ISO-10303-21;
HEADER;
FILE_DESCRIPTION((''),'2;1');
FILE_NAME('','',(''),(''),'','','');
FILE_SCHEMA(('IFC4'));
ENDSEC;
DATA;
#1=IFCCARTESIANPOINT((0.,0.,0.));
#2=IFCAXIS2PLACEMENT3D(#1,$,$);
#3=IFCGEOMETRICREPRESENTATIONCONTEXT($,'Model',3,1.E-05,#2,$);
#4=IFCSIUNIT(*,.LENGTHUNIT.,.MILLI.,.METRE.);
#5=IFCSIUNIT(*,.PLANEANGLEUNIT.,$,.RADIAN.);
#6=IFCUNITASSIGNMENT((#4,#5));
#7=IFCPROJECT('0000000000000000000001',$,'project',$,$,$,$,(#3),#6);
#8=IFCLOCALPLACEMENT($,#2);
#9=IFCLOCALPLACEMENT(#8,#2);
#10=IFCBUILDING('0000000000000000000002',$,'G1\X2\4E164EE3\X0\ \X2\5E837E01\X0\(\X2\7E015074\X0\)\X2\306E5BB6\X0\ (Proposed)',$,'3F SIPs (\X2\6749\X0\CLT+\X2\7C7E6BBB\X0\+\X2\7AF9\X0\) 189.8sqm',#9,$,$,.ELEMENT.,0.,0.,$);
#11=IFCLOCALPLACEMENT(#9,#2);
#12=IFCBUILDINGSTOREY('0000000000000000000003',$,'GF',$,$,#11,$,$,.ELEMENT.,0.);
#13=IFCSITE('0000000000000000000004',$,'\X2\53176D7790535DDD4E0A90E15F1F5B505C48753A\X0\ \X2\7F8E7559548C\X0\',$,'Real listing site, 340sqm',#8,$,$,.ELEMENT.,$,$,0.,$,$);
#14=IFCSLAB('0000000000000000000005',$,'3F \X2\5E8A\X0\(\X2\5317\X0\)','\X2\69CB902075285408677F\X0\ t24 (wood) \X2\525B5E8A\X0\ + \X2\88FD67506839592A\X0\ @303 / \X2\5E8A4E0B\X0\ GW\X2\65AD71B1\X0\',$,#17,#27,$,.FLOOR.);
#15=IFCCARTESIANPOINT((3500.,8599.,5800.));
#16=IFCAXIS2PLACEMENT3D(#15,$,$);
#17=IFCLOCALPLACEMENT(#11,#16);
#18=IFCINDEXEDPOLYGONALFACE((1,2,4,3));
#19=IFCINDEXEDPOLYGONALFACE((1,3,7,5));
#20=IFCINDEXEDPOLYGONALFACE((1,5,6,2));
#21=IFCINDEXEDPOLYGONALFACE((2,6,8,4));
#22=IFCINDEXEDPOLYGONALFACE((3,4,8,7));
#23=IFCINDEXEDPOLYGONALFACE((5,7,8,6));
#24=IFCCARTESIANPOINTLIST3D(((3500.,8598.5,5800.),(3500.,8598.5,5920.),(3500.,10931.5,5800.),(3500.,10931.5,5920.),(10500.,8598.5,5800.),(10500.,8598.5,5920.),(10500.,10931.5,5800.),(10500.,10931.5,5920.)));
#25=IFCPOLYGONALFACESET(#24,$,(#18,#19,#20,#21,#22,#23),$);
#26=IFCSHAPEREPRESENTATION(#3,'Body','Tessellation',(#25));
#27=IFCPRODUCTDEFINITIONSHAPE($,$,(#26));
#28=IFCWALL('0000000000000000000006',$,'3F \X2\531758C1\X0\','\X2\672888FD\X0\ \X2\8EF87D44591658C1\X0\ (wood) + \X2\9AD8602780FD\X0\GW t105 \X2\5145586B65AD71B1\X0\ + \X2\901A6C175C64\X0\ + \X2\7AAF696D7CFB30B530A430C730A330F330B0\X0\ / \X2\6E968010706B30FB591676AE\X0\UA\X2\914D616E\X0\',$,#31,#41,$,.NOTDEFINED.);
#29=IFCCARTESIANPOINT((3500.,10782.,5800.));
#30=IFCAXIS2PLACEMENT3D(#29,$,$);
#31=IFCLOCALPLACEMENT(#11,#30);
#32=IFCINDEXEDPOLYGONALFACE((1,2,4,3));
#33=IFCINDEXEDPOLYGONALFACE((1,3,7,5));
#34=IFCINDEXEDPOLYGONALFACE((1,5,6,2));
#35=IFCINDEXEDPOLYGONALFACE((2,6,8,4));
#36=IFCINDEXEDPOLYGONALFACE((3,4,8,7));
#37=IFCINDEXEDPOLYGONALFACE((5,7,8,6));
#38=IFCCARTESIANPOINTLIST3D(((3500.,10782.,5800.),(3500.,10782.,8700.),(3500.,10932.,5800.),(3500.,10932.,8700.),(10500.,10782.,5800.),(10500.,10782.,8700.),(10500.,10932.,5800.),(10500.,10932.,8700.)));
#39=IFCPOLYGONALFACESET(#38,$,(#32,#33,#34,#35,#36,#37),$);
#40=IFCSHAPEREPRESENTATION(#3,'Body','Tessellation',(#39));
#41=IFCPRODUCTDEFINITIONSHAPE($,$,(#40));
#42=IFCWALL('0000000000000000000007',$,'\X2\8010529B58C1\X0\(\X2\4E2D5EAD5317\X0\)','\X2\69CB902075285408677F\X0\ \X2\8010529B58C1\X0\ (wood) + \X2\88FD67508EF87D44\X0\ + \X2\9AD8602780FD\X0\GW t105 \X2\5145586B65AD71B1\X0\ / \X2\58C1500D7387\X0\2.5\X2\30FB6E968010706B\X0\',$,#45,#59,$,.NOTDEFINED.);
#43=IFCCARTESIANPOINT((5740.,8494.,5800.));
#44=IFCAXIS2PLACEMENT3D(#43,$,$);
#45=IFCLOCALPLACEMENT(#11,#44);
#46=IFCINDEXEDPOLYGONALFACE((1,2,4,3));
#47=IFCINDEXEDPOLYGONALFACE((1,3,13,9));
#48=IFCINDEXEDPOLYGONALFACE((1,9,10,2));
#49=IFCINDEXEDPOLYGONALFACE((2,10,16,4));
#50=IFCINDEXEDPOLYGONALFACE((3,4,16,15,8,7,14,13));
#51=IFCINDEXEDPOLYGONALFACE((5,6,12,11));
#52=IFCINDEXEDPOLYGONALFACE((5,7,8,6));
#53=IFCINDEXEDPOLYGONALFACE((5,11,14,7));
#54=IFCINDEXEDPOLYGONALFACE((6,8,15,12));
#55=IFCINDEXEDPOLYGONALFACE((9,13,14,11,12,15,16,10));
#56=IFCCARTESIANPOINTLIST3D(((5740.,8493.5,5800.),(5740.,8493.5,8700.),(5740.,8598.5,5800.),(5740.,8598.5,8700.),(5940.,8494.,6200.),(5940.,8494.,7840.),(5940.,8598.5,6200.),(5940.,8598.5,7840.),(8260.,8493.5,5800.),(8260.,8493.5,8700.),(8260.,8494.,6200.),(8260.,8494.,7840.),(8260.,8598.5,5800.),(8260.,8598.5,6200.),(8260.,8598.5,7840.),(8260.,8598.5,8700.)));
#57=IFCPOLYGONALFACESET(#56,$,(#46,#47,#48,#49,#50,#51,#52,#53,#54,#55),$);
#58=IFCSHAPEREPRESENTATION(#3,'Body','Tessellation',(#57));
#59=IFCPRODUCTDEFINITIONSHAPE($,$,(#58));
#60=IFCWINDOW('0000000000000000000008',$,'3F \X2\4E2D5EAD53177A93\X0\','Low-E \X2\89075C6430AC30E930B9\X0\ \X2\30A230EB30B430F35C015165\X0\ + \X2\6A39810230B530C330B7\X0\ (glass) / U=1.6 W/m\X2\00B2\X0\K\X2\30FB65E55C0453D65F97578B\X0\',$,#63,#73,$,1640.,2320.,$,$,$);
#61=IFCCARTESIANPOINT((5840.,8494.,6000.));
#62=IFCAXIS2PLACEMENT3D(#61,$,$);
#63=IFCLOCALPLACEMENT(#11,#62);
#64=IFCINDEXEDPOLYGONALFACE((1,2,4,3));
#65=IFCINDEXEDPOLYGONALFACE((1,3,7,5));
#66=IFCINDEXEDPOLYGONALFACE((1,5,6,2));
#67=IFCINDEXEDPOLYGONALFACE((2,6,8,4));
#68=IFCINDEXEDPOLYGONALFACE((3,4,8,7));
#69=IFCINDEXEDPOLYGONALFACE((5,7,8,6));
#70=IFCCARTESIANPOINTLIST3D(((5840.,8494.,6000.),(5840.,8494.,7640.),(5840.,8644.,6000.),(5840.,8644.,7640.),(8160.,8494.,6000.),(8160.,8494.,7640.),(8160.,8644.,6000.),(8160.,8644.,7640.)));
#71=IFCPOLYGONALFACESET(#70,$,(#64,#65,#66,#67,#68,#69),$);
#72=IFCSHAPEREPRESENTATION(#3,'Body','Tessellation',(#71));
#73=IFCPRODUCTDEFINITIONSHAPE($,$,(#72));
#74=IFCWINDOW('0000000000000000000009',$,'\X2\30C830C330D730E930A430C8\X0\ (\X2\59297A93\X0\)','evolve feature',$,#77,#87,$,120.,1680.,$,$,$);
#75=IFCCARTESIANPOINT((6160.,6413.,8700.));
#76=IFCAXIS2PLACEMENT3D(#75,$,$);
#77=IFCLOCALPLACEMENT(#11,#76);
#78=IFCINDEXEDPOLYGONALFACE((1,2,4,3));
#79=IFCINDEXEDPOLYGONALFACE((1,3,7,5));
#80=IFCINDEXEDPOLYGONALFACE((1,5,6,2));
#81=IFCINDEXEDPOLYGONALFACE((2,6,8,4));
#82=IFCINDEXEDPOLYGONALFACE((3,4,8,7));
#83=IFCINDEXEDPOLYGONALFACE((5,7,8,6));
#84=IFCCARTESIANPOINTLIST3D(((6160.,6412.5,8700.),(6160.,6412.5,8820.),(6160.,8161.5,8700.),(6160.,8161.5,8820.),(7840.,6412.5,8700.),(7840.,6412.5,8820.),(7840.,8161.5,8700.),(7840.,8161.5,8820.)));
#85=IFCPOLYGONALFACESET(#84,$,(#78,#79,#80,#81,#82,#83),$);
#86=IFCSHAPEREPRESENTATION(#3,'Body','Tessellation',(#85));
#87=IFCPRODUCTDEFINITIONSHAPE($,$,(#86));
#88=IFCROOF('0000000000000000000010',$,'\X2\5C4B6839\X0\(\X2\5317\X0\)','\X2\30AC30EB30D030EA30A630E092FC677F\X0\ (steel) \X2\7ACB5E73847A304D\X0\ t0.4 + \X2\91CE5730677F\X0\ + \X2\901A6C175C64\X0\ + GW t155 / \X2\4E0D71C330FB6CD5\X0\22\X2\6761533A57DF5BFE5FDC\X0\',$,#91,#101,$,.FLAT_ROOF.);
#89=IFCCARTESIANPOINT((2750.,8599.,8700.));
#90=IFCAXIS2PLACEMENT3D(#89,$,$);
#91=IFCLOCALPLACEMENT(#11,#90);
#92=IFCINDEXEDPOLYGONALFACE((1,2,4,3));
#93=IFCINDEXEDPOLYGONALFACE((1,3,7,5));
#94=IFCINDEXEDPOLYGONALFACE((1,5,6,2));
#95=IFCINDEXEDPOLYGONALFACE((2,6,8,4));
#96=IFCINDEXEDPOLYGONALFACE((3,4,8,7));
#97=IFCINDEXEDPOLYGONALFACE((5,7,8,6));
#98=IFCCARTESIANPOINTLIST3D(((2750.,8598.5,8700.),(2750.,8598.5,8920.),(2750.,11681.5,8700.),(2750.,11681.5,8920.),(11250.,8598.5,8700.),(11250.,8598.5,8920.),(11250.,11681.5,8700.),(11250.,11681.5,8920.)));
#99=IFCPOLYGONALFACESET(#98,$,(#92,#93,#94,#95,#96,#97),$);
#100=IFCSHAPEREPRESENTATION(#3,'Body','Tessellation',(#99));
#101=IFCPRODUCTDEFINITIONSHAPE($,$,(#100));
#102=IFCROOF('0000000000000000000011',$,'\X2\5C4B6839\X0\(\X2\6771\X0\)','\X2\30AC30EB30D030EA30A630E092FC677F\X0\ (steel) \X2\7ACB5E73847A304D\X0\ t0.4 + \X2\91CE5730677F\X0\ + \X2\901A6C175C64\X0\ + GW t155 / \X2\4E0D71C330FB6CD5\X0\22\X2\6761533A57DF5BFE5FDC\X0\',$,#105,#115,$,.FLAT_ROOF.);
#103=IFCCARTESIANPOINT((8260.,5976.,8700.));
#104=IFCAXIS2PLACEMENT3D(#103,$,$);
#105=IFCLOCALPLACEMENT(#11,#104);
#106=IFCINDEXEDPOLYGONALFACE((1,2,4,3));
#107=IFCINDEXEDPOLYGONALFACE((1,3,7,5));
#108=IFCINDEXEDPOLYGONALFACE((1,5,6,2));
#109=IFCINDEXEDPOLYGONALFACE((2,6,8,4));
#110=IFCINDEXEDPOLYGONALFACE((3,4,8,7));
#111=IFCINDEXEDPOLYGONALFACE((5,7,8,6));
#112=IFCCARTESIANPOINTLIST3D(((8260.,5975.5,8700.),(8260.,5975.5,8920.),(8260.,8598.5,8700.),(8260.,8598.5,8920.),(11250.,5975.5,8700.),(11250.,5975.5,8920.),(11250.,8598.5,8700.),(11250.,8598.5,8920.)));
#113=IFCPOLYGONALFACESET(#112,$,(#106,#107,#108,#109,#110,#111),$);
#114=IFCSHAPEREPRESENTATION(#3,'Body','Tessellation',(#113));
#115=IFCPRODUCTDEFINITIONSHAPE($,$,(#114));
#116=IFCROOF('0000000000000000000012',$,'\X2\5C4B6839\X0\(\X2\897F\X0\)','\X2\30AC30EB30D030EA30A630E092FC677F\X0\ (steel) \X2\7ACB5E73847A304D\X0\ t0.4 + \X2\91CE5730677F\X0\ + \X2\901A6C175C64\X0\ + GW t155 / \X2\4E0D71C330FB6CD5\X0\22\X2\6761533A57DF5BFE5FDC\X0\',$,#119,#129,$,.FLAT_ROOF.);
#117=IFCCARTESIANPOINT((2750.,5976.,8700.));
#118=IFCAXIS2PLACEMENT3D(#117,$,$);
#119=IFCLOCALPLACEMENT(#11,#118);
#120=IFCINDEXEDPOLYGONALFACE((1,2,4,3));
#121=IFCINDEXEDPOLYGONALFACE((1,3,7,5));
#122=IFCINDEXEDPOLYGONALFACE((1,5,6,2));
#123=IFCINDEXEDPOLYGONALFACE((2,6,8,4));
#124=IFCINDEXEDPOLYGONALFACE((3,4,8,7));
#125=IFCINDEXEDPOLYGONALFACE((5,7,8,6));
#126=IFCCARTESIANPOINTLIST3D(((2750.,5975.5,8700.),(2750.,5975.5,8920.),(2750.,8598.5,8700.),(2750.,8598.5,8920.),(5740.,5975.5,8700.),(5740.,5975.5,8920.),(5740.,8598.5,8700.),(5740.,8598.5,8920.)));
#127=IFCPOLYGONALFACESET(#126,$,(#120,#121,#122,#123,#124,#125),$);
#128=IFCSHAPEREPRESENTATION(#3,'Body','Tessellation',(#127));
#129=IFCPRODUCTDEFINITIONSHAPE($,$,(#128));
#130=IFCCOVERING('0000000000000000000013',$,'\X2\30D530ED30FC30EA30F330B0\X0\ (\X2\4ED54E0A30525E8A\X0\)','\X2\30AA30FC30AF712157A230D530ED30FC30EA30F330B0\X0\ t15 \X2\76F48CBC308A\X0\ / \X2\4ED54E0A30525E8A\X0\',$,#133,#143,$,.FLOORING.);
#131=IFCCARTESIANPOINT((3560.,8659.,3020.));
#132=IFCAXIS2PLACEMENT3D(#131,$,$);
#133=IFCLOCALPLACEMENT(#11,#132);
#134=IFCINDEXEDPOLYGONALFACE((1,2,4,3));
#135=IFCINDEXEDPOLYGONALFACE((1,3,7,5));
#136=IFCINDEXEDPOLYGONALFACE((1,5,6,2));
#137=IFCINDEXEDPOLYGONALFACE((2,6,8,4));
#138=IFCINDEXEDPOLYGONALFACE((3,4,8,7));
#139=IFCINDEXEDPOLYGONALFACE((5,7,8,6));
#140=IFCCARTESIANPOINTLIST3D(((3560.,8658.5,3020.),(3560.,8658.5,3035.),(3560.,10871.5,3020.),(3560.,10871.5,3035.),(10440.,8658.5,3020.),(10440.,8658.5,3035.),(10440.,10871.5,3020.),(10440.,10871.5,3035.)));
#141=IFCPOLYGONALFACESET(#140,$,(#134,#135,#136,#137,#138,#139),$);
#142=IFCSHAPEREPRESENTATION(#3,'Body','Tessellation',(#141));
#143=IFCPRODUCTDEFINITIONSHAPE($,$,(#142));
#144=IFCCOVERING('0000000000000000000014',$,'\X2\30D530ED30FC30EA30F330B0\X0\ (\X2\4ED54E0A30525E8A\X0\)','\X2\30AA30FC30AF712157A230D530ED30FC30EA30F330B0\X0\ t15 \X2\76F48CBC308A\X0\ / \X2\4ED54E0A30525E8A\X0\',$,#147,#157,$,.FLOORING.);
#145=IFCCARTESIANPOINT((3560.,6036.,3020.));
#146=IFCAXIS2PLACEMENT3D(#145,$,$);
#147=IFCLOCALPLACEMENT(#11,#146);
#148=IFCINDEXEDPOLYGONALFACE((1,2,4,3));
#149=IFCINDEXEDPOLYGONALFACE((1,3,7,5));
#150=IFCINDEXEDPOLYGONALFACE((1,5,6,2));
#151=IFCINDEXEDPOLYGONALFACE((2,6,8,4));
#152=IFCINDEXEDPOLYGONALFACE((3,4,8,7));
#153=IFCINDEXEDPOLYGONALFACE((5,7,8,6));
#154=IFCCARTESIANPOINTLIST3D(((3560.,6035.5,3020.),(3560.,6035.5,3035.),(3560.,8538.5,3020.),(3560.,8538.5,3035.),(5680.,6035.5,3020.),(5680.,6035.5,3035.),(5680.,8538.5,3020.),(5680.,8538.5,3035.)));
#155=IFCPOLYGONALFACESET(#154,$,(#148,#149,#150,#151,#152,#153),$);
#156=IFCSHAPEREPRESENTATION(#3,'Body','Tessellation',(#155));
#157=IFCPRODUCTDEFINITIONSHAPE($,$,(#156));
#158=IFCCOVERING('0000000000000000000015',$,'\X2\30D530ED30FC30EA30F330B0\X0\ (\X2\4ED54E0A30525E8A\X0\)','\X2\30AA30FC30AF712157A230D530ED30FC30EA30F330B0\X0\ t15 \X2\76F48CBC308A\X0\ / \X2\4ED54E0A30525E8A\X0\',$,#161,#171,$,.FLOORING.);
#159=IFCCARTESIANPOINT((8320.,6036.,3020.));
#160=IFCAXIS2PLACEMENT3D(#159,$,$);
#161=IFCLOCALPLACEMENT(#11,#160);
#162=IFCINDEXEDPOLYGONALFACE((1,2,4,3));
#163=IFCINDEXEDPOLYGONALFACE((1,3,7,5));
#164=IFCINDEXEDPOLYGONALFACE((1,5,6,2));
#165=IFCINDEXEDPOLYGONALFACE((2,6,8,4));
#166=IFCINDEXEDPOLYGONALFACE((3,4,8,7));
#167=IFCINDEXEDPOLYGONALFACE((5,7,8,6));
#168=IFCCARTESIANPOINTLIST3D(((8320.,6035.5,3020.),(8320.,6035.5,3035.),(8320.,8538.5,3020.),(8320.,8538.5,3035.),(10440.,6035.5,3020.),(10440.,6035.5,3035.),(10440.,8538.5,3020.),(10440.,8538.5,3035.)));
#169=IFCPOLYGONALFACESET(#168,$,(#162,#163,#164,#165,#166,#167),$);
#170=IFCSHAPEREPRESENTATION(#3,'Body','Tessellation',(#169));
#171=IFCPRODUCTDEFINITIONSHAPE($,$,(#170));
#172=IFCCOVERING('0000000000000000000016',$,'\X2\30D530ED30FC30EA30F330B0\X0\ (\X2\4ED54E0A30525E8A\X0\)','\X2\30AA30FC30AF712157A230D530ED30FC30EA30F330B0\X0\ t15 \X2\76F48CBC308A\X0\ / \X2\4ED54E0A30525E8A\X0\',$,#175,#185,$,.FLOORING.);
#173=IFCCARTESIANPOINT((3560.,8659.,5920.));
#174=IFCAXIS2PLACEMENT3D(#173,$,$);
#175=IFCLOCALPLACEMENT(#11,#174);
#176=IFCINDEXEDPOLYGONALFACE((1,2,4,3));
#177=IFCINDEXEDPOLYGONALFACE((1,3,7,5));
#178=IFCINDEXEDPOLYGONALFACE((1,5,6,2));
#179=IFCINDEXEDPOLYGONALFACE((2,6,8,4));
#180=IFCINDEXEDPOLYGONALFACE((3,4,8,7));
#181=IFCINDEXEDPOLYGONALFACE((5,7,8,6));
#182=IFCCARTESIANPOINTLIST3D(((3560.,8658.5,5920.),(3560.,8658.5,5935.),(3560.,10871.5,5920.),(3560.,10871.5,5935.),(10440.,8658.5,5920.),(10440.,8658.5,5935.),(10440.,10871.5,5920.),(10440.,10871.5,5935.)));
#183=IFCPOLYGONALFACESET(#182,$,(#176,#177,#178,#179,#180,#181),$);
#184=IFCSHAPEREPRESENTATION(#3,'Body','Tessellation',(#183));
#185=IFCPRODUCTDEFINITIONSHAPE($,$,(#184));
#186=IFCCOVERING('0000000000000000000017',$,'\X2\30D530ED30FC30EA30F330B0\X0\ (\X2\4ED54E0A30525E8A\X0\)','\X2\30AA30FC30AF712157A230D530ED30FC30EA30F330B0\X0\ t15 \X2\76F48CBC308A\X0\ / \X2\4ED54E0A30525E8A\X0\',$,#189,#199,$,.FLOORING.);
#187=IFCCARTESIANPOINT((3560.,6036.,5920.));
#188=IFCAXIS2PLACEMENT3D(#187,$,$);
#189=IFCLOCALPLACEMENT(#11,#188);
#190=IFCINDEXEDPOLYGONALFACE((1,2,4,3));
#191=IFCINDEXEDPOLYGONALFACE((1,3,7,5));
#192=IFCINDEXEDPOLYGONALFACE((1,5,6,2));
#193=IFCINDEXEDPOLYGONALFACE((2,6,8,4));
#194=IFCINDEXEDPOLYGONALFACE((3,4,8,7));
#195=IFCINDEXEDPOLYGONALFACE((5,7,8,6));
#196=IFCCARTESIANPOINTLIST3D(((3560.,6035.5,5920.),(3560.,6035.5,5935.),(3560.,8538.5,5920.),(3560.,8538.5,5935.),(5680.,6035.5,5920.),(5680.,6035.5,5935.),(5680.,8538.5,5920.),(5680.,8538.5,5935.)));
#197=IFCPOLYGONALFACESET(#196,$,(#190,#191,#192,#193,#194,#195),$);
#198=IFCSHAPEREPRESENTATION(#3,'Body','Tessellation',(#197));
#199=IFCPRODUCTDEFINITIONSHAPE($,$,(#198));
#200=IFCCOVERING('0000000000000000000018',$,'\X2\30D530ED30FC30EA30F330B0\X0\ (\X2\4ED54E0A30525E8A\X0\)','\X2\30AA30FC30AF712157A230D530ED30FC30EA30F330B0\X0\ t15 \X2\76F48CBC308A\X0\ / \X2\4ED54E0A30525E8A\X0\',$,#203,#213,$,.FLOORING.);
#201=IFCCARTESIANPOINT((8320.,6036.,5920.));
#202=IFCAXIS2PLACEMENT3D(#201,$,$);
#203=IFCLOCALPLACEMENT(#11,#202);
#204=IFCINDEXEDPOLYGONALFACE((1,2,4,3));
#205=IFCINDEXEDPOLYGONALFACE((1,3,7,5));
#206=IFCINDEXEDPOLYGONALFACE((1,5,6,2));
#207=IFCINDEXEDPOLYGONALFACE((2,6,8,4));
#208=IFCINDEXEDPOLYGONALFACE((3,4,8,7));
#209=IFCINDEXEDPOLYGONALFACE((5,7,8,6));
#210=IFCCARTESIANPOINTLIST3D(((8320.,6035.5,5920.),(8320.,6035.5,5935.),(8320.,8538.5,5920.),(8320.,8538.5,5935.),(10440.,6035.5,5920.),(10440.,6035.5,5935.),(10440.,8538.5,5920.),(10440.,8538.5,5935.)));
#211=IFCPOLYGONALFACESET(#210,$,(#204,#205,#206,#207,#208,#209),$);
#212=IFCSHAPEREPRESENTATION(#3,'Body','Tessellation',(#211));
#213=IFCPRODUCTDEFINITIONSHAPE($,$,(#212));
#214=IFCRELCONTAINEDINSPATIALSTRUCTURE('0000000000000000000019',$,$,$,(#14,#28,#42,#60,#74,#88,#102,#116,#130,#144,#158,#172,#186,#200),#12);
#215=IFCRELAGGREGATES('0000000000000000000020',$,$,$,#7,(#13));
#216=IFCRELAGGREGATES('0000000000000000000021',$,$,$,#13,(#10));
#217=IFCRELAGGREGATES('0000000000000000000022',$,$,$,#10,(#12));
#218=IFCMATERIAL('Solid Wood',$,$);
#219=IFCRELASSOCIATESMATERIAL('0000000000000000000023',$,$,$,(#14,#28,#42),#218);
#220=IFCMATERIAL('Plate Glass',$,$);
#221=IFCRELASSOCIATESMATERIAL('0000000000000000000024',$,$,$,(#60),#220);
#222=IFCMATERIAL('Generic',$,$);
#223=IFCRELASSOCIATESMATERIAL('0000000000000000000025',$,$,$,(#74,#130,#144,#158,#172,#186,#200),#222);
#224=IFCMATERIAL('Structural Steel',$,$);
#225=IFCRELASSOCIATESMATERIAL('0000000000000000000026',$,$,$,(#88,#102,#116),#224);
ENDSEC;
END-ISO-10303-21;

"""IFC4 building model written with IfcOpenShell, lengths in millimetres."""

from ifc_helpers import new_model, si_unit, frame, frame_2d, origin, place, context, project, spatial, rectangle, extrude, material, element, fill, save


model = new_model("IFC4")

# Units and contexts
model_context = context("Model", 3, precision=1e-05, world=origin())
ifc_project = project(units=[si_unit("LENGTHUNIT", "METRE", prefix="MILLI"), si_unit("PLANEANGLEUNIT", "RADIAN")], contexts=[model_context])

# Site, building, storey
site_placement = place(None, origin())
site = spatial("IfcSite", under=ifc_project, at=site_placement, Name="北海道川上郡弟子屈町 美留和", ObjectType="Real listing site, 340sqm", CompositionType="ELEMENT", RefElevation=0.0)
building_placement = place(site_placement, origin())
building = spatial("IfcBuilding", under=site, at=building_placement, Name="G1世代 広縁(縁側)の家 (Proposed)", ObjectType="3F SIPs (杉CLT+籾殻+竹) 189.8sqm", CompositionType="ELEMENT", ElevationOfRefHeight=0.0, ElevationOfTerrain=0.0)
storey_placement = place(building_placement, origin())
storey = spatial("IfcBuildingStorey", under=building, at=storey_placement, Name="GF", CompositionType="ELEMENT", Elevation=0.0)

# Slab
ifc_material_1 = material(Name="Solid Wood")
slab_placement = place(storey_placement, frame((3500.0, 8599.0, 5800.0)))
element("IfcSlab", 1, at=slab_placement, inside=storey, material=ifc_material_1, Name="3F 床(北)", Description="構造用合板 t24 (wood) 剛床 + 製材根太 @303 / 床下 GW断熱", PredefinedType="FLOOR", context=model_context, shape_type="SweptSolid", body=[
    extrude(rectangle(XDim=7000.0, YDim=2333.0, at=frame_2d((3500.0, 1166.0))), frame((3500.0, 8599.0, 5800.0)), (0.0, 0.0, 1.0), 120.0),
])

# Wall
wall_1_placement = place(storey_placement, frame((3500.0, 10782.0, 5800.0)))
element("IfcWall", 2, at=wall_1_placement, inside=storey, material=ifc_material_1, Name="3F 北壁", Description="木製 軸組外壁 (wood) + 高性能GW t105 充填断熱 + 通気層 + 窯業系サイディング / 準耐火・外皮UA配慮", PredefinedType="NOTDEFINED", context=model_context, shape_type="SweptSolid", body=[
    extrude(rectangle(XDim=7000.0, YDim=150.0, at=frame_2d((3500.0, 75.0))), frame((3500.0, 10782.0, 5800.0)), (0.0, 0.0, 1.0), 2900.0),
])

# Wall, opening, window
wall_2_placement = place(storey_placement, frame((5740.0, 8494.0, 5800.0)))
wall_2 = element("IfcWall", 3, at=wall_2_placement, inside=storey, material=ifc_material_1, Name="耐力壁(中庭北)", Description="構造用合板 耐力壁 (wood) + 製材軸組 + 高性能GW t105 充填断熱 / 壁倍率2.5・準耐火", PredefinedType="NOTDEFINED", context=model_context, shape_type="SweptSolid", body=[
    extrude(rectangle(XDim=2520.0, YDim=105.0, at=frame_2d((1260.0, 52.0))), frame((5740.0, 8494.0, 5800.0)), (0.0, 0.0, 1.0), 2900.0),
])
opening_placement = place(storey_placement, frame((5840.0, 8494.0, 6000.0)))
opening = element("IfcOpeningElement", 4, at=opening_placement, cuts=wall_2, PredefinedType="NOTDEFINED", context=model_context, shape_type="SweptSolid", body=[
    extrude(rectangle(XDim=2320.0, YDim=150.0, at=frame_2d((1160.0, 75.0))), frame((5840.0, 8494.0, 6000.0)), (0.0, 0.0, 1.0), 1640.0),
])
ifc_material_2 = material(Name="Plate Glass")
window_1_placement = place(storey_placement, frame((5840.0, 8494.0, 6000.0)))
window_1 = element("IfcWindow", 5, at=window_1_placement, inside=storey, material=ifc_material_2, Name="3F 中庭北窓", Description="Low-E 複層ガラス アルゴン封入 + 樹脂サッシ (glass) / U=1.6 W/m²K・日射取得型", OverallHeight=1640.0, OverallWidth=2320.0, context=model_context, shape_type="SweptSolid", body=[
    extrude(rectangle(XDim=2320.0, YDim=150.0, at=frame_2d((1160.0, 75.0))), frame((5840.0, 8494.0, 6000.0)), (0.0, 0.0, 1.0), 1640.0),
])
fill(opening, window_1)

# Window
ifc_material_3 = material(Name="Generic")
window_2_placement = place(storey_placement, frame((6160.0, 6413.0, 8700.0)))
element("IfcWindow", 6, at=window_2_placement, inside=storey, material=ifc_material_3, Name="トップライト (天窓)", Description="evolve feature", OverallHeight=120.0, OverallWidth=1680.0, context=model_context, shape_type="SweptSolid", body=[
    extrude(rectangle(XDim=1680.0, YDim=1749.0, at=frame_2d((840.0, 874.0))), frame((6160.0, 6413.0, 8700.0)), (0.0, 0.0, 1.0), 120.0),
])

# Roofs
ifc_material_4 = material(Name="Structural Steel")
roof_1_placement = place(storey_placement, frame((2750.0, 8599.0, 8700.0)))
element("IfcRoof", 7, at=roof_1_placement, inside=storey, material=ifc_material_4, Name="屋根(北)", Description="ガルバリウム鋼板 (steel) 立平葺き t0.4 + 野地板 + 通気層 + GW t155 / 不燃・法22条区域対応", PredefinedType="FLAT_ROOF", context=model_context, shape_type="SweptSolid", body=[
    extrude(rectangle(XDim=8500.0, YDim=3083.0, at=frame_2d((4250.0, 1541.0))), frame((2750.0, 8599.0, 8700.0)), (0.0, 0.0, 1.0), 220.0),
])
roof_2_placement = place(storey_placement, frame((8260.0, 5976.0, 8700.0)))
element("IfcRoof", 8, at=roof_2_placement, inside=storey, material=ifc_material_4, Name="屋根(東)", Description="ガルバリウム鋼板 (steel) 立平葺き t0.4 + 野地板 + 通気層 + GW t155 / 不燃・法22条区域対応", PredefinedType="FLAT_ROOF", context=model_context, shape_type="SweptSolid", body=[
    extrude(rectangle(XDim=2990.0, YDim=2623.0, at=frame_2d((1495.0, 1311.0))), frame((8260.0, 5976.0, 8700.0)), (0.0, 0.0, 1.0), 220.0),
])
roof_3_placement = place(storey_placement, frame((2750.0, 5976.0, 8700.0)))
element("IfcRoof", 9, at=roof_3_placement, inside=storey, material=ifc_material_4, Name="屋根(西)", Description="ガルバリウム鋼板 (steel) 立平葺き t0.4 + 野地板 + 通気層 + GW t155 / 不燃・法22条区域対応", PredefinedType="FLAT_ROOF", context=model_context, shape_type="SweptSolid", body=[
    extrude(rectangle(XDim=2990.0, YDim=2623.0, at=frame_2d((1495.0, 1311.0))), frame((2750.0, 5976.0, 8700.0)), (0.0, 0.0, 1.0), 220.0),
])

# Coverings
covering_1_placement = place(storey_placement, frame((3560.0, 8659.0, 3020.0)))
element("IfcCovering", 10, at=covering_1_placement, inside=storey, material=ifc_material_3, Name="フローリング (仕上げ床)", Description="オーク無垢フローリング t15 直貼り / 仕上げ床", PredefinedType="FLOORING", context=model_context, shape_type="SweptSolid", body=[
    extrude(rectangle(XDim=6880.0, YDim=2213.0, at=frame_2d((3440.0, 1106.0))), frame((3560.0, 8659.0, 3020.0)), (0.0, 0.0, 1.0), 15.0),
])
covering_2_placement = place(storey_placement, frame((3560.0, 6036.0, 3020.0)))
element("IfcCovering", 11, at=covering_2_placement, inside=storey, material=ifc_material_3, Name="フローリング (仕上げ床)", Description="オーク無垢フローリング t15 直貼り / 仕上げ床", PredefinedType="FLOORING", context=model_context, shape_type="SweptSolid", body=[
    extrude(rectangle(XDim=2120.0, YDim=2503.0, at=frame_2d((1060.0, 1251.0))), frame((3560.0, 6036.0, 3020.0)), (0.0, 0.0, 1.0), 15.0),
])
covering_3_placement = place(storey_placement, frame((8320.0, 6036.0, 3020.0)))
element("IfcCovering", 12, at=covering_3_placement, inside=storey, material=ifc_material_3, Name="フローリング (仕上げ床)", Description="オーク無垢フローリング t15 直貼り / 仕上げ床", PredefinedType="FLOORING", context=model_context, shape_type="SweptSolid", body=[
    extrude(rectangle(XDim=2120.0, YDim=2503.0, at=frame_2d((1060.0, 1251.0))), frame((8320.0, 6036.0, 3020.0)), (0.0, 0.0, 1.0), 15.0),
])
covering_4_placement = place(storey_placement, frame((3560.0, 8659.0, 5920.0)))
element("IfcCovering", 13, at=covering_4_placement, inside=storey, material=ifc_material_3, Name="フローリング (仕上げ床)", Description="オーク無垢フローリング t15 直貼り / 仕上げ床", PredefinedType="FLOORING", context=model_context, shape_type="SweptSolid", body=[
    extrude(rectangle(XDim=6880.0, YDim=2213.0, at=frame_2d((3440.0, 1106.0))), frame((3560.0, 8659.0, 5920.0)), (0.0, 0.0, 1.0), 15.0),
])
covering_5_placement = place(storey_placement, frame((3560.0, 6036.0, 5920.0)))
element("IfcCovering", 14, at=covering_5_placement, inside=storey, material=ifc_material_3, Name="フローリング (仕上げ床)", Description="オーク無垢フローリング t15 直貼り / 仕上げ床", PredefinedType="FLOORING", context=model_context, shape_type="SweptSolid", body=[
    extrude(rectangle(XDim=2120.0, YDim=2503.0, at=frame_2d((1060.0, 1251.0))), frame((3560.0, 6036.0, 5920.0)), (0.0, 0.0, 1.0), 15.0),
])
covering_6_placement = place(storey_placement, frame((8320.0, 6036.0, 5920.0)))
element("IfcCovering", 15, at=covering_6_placement, inside=storey, material=ifc_material_3, Name="フローリング (仕上げ床)", Description="オーク無垢フローリング t15 直貼り / 仕上げ床", PredefinedType="FLOORING", context=model_context, shape_type="SweptSolid", body=[
    extrude(rectangle(XDim=2120.0, YDim=2503.0, at=frame_2d((1060.0, 1251.0))), frame((8320.0, 6036.0, 5920.0)), (0.0, 0.0, 1.0), 15.0),
])

save(model, "model.ifc")
